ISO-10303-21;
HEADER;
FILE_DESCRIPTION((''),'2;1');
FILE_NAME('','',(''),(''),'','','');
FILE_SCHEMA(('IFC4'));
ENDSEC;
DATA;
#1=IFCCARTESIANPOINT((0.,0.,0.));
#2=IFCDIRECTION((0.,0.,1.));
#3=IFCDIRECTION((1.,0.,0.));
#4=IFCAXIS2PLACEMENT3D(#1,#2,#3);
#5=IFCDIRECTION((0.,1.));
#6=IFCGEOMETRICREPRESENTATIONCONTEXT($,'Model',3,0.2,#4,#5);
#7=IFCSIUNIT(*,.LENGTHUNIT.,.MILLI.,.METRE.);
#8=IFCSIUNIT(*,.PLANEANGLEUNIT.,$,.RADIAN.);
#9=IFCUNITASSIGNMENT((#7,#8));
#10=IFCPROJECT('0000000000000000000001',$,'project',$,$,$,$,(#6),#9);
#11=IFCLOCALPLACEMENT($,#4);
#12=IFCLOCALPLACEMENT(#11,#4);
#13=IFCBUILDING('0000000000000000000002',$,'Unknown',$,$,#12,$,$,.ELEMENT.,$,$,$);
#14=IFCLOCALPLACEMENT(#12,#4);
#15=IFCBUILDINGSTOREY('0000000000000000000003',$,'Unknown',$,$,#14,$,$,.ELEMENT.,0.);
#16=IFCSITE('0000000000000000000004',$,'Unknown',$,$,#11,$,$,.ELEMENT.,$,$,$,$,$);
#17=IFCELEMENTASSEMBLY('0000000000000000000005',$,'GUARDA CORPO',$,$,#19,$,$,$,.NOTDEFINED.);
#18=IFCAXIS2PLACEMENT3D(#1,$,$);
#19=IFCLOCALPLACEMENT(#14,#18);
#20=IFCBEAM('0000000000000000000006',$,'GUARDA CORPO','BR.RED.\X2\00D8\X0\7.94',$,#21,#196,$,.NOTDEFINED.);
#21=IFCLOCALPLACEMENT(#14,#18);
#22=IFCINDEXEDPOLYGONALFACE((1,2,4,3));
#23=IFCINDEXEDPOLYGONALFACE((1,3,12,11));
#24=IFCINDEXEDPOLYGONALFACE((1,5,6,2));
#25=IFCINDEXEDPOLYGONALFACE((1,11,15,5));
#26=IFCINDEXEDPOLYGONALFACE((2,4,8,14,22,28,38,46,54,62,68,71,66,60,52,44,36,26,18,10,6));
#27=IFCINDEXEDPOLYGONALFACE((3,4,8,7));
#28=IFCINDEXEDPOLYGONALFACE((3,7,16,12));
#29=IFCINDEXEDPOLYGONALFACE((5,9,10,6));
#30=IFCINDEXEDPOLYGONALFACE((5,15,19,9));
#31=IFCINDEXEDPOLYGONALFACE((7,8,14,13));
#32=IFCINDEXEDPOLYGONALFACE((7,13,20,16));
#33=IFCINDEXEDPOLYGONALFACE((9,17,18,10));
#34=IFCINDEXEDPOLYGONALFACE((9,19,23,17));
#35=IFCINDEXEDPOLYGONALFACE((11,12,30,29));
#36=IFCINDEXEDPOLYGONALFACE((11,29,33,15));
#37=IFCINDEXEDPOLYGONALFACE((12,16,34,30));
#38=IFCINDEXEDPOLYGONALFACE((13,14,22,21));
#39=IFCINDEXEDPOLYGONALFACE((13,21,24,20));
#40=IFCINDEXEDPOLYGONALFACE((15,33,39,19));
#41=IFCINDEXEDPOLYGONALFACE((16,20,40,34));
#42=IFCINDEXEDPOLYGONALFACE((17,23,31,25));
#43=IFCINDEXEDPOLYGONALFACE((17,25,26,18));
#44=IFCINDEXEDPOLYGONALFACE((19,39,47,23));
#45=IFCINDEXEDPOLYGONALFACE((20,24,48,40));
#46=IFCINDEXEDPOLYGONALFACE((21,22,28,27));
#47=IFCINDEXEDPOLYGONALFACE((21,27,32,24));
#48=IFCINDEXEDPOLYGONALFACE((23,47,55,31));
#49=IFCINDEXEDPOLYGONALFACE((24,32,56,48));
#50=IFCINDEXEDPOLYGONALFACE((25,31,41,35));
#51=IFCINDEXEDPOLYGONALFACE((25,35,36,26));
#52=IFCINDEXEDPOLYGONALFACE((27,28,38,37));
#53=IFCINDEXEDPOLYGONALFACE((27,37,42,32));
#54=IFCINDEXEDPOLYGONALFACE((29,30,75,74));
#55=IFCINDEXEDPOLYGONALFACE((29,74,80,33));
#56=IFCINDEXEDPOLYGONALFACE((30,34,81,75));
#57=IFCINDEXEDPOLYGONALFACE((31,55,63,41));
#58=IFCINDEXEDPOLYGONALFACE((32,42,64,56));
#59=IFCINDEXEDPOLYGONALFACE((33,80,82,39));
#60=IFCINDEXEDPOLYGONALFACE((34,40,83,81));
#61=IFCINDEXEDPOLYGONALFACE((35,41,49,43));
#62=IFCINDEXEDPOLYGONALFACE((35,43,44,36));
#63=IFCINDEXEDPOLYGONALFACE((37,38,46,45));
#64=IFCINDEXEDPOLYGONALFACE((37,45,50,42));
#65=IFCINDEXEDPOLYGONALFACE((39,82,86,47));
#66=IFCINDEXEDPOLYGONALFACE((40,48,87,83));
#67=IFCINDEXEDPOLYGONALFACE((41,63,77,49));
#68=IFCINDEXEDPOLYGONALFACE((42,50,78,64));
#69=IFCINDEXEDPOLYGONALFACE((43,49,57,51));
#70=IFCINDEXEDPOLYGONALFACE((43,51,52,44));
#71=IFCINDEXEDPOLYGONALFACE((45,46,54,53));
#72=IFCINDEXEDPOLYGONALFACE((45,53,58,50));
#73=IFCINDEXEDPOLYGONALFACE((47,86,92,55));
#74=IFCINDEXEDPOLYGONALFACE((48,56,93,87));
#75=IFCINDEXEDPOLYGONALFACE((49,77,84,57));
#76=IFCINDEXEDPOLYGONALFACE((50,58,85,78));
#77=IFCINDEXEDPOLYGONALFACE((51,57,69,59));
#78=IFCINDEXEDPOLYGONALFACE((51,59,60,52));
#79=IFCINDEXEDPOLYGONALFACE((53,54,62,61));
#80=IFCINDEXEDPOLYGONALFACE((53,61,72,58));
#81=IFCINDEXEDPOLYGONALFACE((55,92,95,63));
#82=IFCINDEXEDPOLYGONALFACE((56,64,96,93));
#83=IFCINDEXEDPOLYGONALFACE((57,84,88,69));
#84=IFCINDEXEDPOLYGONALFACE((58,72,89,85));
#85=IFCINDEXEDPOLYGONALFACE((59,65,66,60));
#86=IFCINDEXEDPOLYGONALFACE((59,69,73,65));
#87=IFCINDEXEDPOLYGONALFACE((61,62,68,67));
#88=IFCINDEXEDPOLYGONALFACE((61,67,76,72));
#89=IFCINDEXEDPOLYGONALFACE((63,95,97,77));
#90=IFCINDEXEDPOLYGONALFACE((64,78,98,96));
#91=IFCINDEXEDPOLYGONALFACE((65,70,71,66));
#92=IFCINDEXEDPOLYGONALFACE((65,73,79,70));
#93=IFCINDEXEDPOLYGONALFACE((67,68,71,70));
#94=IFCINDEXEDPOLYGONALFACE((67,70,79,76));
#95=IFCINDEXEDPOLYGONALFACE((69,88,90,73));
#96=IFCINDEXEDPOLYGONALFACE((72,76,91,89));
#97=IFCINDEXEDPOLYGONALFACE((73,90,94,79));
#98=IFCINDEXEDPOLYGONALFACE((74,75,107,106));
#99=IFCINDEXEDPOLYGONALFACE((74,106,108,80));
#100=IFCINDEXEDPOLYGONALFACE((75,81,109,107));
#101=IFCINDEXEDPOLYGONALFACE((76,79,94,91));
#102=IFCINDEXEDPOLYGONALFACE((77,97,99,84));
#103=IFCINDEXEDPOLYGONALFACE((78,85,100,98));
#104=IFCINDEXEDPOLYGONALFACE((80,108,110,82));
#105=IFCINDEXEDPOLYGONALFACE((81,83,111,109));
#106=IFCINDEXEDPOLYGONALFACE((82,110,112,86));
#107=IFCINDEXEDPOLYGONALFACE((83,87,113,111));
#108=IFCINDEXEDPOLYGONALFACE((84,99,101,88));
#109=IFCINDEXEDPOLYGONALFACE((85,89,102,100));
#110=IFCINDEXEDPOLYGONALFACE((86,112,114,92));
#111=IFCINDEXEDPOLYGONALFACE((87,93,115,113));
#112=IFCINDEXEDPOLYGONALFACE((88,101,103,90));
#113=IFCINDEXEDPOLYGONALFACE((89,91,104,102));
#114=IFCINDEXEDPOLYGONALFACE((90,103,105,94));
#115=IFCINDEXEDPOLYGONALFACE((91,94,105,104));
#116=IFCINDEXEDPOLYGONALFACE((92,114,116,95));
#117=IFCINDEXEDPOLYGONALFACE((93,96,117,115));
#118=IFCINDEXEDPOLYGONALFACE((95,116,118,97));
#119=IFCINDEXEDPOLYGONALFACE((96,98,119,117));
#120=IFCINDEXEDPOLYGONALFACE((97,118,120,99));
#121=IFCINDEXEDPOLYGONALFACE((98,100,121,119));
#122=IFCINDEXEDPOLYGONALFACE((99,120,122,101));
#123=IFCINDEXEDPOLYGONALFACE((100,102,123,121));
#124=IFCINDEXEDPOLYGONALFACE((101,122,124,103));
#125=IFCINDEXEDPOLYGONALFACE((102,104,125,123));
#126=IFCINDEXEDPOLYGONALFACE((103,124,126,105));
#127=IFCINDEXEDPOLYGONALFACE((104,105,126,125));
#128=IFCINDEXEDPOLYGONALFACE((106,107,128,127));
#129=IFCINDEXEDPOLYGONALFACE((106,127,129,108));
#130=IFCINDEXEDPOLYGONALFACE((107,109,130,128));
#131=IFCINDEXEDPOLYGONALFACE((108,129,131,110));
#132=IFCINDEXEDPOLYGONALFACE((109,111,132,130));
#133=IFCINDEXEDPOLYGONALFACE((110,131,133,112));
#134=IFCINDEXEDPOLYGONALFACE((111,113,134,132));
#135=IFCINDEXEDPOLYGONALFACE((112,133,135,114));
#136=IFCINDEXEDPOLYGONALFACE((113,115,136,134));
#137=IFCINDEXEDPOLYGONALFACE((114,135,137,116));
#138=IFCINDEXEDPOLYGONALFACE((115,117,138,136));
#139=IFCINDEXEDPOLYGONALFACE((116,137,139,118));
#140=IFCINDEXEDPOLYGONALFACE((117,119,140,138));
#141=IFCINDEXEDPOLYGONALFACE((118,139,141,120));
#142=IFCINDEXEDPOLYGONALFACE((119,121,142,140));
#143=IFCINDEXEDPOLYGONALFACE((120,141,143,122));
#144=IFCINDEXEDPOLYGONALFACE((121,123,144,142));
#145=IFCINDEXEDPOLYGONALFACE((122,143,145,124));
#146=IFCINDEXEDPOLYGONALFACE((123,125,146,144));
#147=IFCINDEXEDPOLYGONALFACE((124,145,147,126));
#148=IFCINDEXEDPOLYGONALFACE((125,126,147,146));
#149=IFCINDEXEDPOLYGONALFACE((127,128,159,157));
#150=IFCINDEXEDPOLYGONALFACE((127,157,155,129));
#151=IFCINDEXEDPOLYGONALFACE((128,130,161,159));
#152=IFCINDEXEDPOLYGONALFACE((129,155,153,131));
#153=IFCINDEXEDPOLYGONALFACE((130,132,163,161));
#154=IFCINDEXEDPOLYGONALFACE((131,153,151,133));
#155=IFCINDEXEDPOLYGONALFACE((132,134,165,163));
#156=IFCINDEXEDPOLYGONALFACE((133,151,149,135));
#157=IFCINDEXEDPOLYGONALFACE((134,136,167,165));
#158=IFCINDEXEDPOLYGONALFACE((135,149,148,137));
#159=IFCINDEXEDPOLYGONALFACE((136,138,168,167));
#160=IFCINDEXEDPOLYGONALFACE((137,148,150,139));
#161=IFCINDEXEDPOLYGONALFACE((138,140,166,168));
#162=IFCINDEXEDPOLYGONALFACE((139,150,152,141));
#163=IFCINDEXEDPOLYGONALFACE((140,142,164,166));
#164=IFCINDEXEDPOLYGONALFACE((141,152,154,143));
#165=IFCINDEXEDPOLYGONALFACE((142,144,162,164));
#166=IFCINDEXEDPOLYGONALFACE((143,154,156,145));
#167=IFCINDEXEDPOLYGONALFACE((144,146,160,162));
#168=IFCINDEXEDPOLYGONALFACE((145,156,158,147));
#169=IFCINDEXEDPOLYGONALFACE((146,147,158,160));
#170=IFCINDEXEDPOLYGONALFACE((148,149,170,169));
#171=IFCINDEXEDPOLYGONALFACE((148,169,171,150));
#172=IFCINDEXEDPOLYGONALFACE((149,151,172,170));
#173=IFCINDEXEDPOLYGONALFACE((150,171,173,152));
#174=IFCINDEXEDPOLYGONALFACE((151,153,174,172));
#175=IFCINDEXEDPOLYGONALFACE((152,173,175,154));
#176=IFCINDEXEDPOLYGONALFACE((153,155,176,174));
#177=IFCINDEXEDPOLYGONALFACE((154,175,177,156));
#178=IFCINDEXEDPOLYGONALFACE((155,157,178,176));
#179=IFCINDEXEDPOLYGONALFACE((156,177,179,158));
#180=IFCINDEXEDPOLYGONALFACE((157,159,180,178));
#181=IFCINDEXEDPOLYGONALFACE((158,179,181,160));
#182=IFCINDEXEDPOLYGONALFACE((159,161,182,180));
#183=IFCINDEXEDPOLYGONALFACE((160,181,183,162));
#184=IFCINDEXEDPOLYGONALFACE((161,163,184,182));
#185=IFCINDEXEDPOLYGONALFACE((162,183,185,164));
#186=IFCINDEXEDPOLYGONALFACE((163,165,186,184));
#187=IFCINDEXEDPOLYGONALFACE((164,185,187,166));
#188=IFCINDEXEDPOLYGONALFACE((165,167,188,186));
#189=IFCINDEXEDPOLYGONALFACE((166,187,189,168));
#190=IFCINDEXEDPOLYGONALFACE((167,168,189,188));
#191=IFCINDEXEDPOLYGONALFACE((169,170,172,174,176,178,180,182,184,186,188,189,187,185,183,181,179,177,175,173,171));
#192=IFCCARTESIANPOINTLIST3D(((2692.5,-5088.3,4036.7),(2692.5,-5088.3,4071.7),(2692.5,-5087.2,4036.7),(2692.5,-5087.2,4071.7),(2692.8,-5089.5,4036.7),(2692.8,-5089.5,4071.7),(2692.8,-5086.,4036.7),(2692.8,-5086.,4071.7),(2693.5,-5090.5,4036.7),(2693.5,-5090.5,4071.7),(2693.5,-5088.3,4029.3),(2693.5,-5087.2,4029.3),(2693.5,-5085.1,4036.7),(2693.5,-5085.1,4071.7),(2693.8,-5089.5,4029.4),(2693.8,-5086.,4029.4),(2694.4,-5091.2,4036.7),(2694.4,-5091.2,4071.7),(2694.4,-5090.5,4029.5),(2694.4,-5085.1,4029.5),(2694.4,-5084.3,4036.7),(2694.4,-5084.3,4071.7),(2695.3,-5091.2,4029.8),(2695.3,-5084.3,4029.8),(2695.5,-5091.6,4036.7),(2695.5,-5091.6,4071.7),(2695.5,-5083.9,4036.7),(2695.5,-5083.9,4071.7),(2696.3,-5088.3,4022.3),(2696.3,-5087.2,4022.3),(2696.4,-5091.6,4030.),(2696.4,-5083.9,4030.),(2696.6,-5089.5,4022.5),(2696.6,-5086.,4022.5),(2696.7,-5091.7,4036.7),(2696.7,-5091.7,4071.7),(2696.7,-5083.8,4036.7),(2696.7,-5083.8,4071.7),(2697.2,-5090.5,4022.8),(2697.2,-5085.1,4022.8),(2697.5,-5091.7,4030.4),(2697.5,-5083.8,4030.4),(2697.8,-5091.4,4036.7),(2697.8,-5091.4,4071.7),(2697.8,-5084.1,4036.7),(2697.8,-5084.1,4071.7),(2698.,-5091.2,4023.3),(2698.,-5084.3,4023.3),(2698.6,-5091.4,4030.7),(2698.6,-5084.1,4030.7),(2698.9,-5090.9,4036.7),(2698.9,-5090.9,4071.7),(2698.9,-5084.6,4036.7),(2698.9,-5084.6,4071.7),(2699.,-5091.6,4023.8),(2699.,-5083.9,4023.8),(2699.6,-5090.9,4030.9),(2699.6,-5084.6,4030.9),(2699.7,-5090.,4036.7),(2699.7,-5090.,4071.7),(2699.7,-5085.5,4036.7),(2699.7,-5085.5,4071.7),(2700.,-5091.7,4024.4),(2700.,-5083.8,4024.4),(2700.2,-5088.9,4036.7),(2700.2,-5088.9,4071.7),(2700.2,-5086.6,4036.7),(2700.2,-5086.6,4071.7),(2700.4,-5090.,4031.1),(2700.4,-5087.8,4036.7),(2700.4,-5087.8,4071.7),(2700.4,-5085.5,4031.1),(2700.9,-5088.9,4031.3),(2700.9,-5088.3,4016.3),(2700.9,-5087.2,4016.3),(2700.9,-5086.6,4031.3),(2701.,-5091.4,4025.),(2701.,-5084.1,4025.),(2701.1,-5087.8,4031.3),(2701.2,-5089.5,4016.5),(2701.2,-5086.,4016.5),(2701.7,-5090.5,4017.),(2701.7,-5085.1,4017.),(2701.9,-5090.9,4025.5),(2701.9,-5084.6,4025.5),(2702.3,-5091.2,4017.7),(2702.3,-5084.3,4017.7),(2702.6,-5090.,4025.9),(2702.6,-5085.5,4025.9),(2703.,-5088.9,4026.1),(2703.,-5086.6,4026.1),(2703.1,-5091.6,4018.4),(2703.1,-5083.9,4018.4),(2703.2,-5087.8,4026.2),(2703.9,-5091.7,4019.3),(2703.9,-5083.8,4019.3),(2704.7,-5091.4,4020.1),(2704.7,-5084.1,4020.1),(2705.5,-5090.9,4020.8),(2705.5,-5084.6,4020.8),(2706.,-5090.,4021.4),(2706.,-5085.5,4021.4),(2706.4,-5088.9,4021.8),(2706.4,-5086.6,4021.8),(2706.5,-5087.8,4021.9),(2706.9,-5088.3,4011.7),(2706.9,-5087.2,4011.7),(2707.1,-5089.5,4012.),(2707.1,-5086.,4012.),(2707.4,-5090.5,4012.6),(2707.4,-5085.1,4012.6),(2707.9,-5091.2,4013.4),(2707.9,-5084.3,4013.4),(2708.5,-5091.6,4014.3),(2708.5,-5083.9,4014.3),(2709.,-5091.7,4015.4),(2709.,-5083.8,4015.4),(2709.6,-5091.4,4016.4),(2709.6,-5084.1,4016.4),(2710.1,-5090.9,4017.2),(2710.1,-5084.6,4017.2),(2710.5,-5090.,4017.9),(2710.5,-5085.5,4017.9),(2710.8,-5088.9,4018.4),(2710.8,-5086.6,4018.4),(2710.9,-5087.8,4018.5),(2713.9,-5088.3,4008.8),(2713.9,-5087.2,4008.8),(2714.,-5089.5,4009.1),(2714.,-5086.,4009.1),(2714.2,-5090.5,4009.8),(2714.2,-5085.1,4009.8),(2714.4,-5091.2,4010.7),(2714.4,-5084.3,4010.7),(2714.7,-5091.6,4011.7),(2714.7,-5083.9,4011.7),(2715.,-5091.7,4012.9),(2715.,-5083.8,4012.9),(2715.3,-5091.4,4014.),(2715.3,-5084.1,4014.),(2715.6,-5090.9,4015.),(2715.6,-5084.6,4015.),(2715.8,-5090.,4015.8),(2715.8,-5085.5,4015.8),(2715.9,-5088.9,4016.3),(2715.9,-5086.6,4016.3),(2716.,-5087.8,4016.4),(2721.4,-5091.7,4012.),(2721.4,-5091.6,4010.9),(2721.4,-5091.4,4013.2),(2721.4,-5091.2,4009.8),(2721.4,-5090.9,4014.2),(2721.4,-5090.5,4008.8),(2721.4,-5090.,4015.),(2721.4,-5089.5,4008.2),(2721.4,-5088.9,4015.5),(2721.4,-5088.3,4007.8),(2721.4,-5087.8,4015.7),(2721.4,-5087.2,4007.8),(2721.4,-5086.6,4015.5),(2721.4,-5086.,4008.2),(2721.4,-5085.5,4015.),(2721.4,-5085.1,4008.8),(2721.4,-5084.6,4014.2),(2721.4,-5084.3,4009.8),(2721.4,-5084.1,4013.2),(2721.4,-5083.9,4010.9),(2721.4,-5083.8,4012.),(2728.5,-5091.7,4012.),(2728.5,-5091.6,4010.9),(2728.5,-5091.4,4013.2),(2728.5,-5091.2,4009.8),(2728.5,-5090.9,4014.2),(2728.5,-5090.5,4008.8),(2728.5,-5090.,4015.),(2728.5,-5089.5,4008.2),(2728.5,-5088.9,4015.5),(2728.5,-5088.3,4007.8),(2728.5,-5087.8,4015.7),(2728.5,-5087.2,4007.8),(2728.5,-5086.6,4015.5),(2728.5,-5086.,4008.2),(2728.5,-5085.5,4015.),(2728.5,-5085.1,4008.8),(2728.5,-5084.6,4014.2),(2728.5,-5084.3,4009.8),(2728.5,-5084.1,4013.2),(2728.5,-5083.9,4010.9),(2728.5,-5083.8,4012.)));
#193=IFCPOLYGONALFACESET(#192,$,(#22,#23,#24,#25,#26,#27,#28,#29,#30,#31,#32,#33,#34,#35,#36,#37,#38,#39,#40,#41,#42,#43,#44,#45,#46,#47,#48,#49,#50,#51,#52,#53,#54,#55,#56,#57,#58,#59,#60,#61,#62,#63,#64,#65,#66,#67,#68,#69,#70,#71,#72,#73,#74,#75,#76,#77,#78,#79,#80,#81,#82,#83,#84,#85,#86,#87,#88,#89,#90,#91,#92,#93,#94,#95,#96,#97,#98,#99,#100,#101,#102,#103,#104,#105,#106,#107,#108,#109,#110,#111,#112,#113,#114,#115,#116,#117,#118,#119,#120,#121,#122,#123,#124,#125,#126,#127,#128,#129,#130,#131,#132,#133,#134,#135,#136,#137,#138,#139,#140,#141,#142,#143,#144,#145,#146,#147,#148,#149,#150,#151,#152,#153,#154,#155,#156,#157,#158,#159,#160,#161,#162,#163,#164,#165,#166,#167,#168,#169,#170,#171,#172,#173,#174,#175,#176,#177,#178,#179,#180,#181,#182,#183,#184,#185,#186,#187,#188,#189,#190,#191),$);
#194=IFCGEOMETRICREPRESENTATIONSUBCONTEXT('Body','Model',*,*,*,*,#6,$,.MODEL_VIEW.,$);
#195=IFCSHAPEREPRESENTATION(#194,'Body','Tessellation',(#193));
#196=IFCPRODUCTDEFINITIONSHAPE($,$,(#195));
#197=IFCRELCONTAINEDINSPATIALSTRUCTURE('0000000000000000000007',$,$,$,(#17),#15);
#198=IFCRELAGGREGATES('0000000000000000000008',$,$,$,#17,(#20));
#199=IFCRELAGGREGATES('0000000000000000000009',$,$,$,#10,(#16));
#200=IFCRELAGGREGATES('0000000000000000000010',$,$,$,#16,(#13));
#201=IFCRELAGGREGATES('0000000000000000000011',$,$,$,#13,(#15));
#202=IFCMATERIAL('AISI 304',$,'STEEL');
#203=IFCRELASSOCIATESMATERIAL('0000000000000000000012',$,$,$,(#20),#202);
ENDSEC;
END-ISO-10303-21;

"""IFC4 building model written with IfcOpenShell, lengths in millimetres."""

from ifc_helpers import new_model, entity, si_unit, direction, frame, origin_with_axes, place, context, subcontext, project, spatial, material, element, aggregate, save


model = new_model("IFC4")

# Units and contexts
model_context = context("Model", 3, precision=0.2, world=origin_with_axes(), true_north=direction((0.0, 1.0)))
body_context = subcontext(model_context, "Body", "Model", "MODEL_VIEW")
ifc_project = project(units=[si_unit("LENGTHUNIT", "METRE", prefix="MILLI"), si_unit("PLANEANGLEUNIT", "RADIAN")], contexts=[model_context])

# Site, building, storey
site_placement = place(None, origin_with_axes())
site = spatial("IfcSite", under=ifc_project, at=site_placement, Name="Unknown", CompositionType="ELEMENT")
building_placement = place(site_placement, origin_with_axes())
building = spatial("IfcBuilding", under=site, at=building_placement, Name="Unknown", CompositionType="ELEMENT")
storey_placement = place(building_placement, origin_with_axes())
storey = spatial("IfcBuildingStorey", under=building, at=storey_placement, Name="Unknown", CompositionType="ELEMENT", Elevation=0.0)

# Shared definitions
ifc_material_1 = material(Name="AISI 304", Category="STEEL")

# Element assembly, beam
assembly_1_placement = place(storey_placement, frame((2747.5, -5087.8, 3415.0), z_axis=(-1.0, 0.000512, 0.000003), x_axis=(0.000003, 0.000003, 1.0)))
assembly_1 = element("IfcElementAssembly", 1, at=assembly_1_placement, inside=storey, Name="GUARDA CORPO", PredefinedType="NOTDEFINED")
beam_1_placement = place(assembly_1_placement, frame((656.7, 0.0, 51.2), z_axis=(-0.000003, 0.000513, -1.0), x_axis=(-1.0, 0.0, 0.000003)))
beam_1 = element("IfcBeam", 2, at=beam_1_placement, material=ifc_material_1, Name="GUARDA CORPO", Description="BR.RED.Ø7.94", PredefinedType="NOTDEFINED", context=body_context, shape_type="SolidModel", body=[
    entity("IfcSweptDiskSolid", entity("IfcIndexedPolyCurve", entity("IfcCartesianPointList3D", [[0.0, 0.0, 0.0], [35.0, 0.0, 0.0], [52.7, 0.0, 7.3], [60.0, 0.0, 25.0], [60.0, 0.0, 32.1]]), [entity("IfcLineIndex", [1, 2]), entity("IfcArcIndex", [2, 3, 4]), entity("IfcLineIndex", [4, 5])]), 4.0),
])

aggregate(assembly_1, [beam_1])

save(model, "model.ifc")
